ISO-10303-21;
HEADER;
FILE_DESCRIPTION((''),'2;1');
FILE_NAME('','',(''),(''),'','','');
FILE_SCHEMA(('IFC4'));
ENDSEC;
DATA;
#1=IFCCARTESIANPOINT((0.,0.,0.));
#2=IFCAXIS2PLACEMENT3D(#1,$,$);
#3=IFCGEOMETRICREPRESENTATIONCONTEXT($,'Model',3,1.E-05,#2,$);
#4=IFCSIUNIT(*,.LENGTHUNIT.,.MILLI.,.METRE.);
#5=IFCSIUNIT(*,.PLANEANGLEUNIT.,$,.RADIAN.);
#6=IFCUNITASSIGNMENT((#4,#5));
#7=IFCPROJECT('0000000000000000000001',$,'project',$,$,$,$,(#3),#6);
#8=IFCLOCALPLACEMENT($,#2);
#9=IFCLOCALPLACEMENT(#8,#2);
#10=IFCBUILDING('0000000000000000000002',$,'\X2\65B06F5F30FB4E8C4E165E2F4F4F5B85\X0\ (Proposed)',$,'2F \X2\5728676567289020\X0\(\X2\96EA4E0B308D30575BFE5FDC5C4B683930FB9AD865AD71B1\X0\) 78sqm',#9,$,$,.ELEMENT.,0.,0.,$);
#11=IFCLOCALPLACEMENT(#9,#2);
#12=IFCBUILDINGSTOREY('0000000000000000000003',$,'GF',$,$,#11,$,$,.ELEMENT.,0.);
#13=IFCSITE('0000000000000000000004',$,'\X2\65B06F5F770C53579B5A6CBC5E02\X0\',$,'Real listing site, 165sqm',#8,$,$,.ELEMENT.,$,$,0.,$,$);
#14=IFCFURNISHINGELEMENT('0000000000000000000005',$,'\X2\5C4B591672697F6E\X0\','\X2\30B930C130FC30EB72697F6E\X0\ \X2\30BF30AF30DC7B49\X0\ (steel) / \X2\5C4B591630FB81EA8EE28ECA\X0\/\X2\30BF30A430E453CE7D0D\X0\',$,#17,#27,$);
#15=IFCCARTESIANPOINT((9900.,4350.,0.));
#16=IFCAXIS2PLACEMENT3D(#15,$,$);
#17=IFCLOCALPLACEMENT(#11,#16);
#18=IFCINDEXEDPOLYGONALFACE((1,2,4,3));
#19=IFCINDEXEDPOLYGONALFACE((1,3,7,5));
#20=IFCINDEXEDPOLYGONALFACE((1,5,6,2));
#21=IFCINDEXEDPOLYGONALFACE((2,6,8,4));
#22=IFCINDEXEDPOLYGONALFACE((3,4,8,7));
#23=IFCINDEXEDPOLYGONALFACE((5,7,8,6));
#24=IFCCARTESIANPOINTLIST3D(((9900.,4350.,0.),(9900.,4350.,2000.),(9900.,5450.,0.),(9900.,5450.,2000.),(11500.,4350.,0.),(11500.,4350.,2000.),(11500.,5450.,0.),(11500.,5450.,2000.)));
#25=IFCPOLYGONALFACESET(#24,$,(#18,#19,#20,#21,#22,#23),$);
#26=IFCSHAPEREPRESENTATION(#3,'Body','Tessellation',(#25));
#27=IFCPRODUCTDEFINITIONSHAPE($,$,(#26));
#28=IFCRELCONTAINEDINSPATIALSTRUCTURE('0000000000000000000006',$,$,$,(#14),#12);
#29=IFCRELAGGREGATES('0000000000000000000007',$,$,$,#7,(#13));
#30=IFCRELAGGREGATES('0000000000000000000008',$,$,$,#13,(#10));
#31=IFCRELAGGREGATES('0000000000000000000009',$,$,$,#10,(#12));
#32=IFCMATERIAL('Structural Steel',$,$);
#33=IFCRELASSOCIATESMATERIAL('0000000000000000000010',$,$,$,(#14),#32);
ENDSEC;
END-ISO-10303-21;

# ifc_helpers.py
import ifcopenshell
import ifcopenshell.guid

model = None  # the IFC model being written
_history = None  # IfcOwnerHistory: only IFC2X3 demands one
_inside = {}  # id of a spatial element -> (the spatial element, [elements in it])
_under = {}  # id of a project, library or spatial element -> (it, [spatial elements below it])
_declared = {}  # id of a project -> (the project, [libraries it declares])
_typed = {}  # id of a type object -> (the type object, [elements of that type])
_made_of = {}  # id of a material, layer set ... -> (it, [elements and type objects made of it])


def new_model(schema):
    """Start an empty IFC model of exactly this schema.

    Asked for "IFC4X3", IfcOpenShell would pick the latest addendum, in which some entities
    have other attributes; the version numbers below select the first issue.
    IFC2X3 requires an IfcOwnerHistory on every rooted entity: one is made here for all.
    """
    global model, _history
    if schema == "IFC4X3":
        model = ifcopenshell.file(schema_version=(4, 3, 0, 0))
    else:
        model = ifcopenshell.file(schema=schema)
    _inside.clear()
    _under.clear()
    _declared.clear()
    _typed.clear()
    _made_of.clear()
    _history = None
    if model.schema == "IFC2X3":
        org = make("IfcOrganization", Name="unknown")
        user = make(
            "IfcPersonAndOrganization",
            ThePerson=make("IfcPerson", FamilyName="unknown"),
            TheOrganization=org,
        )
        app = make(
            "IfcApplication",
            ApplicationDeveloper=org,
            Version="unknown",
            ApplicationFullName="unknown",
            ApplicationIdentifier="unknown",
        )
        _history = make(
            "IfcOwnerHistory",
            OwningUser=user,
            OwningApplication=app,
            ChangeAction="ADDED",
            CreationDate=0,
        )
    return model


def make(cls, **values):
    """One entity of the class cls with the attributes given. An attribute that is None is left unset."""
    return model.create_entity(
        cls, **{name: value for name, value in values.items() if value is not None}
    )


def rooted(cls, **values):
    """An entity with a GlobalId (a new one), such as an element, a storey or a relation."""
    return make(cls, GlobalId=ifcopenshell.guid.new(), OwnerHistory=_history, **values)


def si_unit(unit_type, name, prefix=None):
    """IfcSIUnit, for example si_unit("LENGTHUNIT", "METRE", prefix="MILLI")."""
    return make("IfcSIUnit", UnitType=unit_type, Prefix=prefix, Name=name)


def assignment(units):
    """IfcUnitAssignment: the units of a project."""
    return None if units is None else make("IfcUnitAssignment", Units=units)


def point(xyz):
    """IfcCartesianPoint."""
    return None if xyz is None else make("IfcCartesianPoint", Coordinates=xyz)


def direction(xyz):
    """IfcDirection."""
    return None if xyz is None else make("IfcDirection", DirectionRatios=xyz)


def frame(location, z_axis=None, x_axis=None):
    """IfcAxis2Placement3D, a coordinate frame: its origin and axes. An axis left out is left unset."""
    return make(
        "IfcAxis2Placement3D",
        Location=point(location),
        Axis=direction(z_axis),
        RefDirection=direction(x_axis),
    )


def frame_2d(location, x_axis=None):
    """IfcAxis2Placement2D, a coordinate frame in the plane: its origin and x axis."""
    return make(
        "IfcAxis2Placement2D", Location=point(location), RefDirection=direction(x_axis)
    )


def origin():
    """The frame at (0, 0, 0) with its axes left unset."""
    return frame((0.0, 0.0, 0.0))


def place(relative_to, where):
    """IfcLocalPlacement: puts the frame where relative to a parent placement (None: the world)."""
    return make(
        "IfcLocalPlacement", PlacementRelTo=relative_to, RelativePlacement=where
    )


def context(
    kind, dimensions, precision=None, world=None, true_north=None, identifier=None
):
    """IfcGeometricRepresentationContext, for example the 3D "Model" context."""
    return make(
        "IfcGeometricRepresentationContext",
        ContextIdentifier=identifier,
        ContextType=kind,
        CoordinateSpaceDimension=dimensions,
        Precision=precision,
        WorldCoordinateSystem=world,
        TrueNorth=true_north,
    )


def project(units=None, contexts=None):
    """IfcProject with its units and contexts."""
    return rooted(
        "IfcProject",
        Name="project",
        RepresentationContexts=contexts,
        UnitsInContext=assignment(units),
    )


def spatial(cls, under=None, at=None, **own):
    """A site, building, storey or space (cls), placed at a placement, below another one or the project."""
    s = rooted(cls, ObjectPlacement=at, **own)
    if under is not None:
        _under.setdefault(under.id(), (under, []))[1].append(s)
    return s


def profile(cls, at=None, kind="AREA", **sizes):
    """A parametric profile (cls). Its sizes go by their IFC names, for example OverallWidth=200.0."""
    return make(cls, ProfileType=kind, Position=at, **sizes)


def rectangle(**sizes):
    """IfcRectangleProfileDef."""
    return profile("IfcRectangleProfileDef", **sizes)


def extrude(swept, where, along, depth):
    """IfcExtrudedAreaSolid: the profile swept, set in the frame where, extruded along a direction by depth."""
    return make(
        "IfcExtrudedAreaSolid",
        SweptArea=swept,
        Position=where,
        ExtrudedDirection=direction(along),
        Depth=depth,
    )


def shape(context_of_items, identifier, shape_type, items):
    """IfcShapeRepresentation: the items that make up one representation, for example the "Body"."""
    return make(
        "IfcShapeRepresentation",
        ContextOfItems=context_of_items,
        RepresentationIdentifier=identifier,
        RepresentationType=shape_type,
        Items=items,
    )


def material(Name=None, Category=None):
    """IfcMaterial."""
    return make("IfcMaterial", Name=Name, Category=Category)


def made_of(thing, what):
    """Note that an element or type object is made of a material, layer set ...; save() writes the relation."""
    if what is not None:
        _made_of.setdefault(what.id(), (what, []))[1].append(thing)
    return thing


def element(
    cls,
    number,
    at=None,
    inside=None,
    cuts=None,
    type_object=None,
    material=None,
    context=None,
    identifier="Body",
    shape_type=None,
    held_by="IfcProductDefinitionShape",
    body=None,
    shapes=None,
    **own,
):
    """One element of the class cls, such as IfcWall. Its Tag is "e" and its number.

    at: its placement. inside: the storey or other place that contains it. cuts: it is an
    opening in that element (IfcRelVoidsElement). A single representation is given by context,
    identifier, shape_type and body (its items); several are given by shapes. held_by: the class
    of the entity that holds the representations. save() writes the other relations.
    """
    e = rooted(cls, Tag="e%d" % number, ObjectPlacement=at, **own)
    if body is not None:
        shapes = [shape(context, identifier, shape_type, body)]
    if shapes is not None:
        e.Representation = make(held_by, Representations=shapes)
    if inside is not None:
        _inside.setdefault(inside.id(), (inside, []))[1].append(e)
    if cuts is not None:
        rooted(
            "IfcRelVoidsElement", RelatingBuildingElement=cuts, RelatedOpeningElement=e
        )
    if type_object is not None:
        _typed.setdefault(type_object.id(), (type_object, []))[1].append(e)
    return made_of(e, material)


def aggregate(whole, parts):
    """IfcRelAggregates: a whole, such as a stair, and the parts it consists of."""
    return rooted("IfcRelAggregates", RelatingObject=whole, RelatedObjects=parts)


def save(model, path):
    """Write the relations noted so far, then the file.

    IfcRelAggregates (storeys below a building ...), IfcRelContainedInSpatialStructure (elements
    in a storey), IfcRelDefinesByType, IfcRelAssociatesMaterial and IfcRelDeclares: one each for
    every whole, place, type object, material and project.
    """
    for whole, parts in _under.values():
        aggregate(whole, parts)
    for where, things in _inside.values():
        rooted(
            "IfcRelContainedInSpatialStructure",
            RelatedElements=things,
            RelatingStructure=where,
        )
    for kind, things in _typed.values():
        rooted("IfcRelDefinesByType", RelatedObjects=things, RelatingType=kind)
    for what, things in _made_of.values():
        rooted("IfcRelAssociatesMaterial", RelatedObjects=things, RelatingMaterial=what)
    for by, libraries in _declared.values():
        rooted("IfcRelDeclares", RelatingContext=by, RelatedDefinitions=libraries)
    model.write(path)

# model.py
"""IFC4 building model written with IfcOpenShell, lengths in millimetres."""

from ifc_helpers import new_model, si_unit, frame, frame_2d, origin, place, context, project, spatial, rectangle, extrude, material, element, save


model = new_model("IFC4")

# Units and contexts
model_context = context("Model", 3, precision=1e-05, world=origin())
ifc_project = project(units=[si_unit("LENGTHUNIT", "METRE", prefix="MILLI"), si_unit("PLANEANGLEUNIT", "RADIAN")], contexts=[model_context])

# Site, building, storey
site_placement = place(None, origin())
site = spatial("IfcSite", under=ifc_project, at=site_placement, Name="新潟県南魚沼市", ObjectType="Real listing site, 165sqm", CompositionType="ELEMENT", RefElevation=0.0)
building_placement = place(site_placement, origin())
building = spatial("IfcBuilding", under=site, at=building_placement, Name="新潟・二世帯住宅 (Proposed)", ObjectType="2F 在来木造(雪下ろし対応屋根・高断熱) 78sqm", CompositionType="ELEMENT", ElevationOfRefHeight=0.0, ElevationOfTerrain=0.0)
storey_placement = place(building_placement, origin())
storey = spatial("IfcBuildingStorey", under=building, at=storey_placement, Name="GF", CompositionType="ELEMENT", Elevation=0.0)

# Shared definitions
ifc_material_1 = material(Name="Structural Steel")

# Furnishing element
furnishing_1_placement = place(storey_placement, frame((9900.0, 4350.0, 0.0)))
element("IfcFurnishingElement", 1, at=furnishing_1_placement, inside=storey, material=ifc_material_1, Name="屋外物置", Description="スチール物置 タクボ等 (steel) / 屋外・自転車/タイヤ収納", context=model_context, shape_type="SweptSolid", body=[
    extrude(rectangle(XDim=1600.0, YDim=1100.0, at=frame_2d((800.0, 550.0))), frame((9900.0, 4350.0, 0.0)), (0.0, 0.0, 1.0), 2000.0),
])

save(model, "model.ifc")
